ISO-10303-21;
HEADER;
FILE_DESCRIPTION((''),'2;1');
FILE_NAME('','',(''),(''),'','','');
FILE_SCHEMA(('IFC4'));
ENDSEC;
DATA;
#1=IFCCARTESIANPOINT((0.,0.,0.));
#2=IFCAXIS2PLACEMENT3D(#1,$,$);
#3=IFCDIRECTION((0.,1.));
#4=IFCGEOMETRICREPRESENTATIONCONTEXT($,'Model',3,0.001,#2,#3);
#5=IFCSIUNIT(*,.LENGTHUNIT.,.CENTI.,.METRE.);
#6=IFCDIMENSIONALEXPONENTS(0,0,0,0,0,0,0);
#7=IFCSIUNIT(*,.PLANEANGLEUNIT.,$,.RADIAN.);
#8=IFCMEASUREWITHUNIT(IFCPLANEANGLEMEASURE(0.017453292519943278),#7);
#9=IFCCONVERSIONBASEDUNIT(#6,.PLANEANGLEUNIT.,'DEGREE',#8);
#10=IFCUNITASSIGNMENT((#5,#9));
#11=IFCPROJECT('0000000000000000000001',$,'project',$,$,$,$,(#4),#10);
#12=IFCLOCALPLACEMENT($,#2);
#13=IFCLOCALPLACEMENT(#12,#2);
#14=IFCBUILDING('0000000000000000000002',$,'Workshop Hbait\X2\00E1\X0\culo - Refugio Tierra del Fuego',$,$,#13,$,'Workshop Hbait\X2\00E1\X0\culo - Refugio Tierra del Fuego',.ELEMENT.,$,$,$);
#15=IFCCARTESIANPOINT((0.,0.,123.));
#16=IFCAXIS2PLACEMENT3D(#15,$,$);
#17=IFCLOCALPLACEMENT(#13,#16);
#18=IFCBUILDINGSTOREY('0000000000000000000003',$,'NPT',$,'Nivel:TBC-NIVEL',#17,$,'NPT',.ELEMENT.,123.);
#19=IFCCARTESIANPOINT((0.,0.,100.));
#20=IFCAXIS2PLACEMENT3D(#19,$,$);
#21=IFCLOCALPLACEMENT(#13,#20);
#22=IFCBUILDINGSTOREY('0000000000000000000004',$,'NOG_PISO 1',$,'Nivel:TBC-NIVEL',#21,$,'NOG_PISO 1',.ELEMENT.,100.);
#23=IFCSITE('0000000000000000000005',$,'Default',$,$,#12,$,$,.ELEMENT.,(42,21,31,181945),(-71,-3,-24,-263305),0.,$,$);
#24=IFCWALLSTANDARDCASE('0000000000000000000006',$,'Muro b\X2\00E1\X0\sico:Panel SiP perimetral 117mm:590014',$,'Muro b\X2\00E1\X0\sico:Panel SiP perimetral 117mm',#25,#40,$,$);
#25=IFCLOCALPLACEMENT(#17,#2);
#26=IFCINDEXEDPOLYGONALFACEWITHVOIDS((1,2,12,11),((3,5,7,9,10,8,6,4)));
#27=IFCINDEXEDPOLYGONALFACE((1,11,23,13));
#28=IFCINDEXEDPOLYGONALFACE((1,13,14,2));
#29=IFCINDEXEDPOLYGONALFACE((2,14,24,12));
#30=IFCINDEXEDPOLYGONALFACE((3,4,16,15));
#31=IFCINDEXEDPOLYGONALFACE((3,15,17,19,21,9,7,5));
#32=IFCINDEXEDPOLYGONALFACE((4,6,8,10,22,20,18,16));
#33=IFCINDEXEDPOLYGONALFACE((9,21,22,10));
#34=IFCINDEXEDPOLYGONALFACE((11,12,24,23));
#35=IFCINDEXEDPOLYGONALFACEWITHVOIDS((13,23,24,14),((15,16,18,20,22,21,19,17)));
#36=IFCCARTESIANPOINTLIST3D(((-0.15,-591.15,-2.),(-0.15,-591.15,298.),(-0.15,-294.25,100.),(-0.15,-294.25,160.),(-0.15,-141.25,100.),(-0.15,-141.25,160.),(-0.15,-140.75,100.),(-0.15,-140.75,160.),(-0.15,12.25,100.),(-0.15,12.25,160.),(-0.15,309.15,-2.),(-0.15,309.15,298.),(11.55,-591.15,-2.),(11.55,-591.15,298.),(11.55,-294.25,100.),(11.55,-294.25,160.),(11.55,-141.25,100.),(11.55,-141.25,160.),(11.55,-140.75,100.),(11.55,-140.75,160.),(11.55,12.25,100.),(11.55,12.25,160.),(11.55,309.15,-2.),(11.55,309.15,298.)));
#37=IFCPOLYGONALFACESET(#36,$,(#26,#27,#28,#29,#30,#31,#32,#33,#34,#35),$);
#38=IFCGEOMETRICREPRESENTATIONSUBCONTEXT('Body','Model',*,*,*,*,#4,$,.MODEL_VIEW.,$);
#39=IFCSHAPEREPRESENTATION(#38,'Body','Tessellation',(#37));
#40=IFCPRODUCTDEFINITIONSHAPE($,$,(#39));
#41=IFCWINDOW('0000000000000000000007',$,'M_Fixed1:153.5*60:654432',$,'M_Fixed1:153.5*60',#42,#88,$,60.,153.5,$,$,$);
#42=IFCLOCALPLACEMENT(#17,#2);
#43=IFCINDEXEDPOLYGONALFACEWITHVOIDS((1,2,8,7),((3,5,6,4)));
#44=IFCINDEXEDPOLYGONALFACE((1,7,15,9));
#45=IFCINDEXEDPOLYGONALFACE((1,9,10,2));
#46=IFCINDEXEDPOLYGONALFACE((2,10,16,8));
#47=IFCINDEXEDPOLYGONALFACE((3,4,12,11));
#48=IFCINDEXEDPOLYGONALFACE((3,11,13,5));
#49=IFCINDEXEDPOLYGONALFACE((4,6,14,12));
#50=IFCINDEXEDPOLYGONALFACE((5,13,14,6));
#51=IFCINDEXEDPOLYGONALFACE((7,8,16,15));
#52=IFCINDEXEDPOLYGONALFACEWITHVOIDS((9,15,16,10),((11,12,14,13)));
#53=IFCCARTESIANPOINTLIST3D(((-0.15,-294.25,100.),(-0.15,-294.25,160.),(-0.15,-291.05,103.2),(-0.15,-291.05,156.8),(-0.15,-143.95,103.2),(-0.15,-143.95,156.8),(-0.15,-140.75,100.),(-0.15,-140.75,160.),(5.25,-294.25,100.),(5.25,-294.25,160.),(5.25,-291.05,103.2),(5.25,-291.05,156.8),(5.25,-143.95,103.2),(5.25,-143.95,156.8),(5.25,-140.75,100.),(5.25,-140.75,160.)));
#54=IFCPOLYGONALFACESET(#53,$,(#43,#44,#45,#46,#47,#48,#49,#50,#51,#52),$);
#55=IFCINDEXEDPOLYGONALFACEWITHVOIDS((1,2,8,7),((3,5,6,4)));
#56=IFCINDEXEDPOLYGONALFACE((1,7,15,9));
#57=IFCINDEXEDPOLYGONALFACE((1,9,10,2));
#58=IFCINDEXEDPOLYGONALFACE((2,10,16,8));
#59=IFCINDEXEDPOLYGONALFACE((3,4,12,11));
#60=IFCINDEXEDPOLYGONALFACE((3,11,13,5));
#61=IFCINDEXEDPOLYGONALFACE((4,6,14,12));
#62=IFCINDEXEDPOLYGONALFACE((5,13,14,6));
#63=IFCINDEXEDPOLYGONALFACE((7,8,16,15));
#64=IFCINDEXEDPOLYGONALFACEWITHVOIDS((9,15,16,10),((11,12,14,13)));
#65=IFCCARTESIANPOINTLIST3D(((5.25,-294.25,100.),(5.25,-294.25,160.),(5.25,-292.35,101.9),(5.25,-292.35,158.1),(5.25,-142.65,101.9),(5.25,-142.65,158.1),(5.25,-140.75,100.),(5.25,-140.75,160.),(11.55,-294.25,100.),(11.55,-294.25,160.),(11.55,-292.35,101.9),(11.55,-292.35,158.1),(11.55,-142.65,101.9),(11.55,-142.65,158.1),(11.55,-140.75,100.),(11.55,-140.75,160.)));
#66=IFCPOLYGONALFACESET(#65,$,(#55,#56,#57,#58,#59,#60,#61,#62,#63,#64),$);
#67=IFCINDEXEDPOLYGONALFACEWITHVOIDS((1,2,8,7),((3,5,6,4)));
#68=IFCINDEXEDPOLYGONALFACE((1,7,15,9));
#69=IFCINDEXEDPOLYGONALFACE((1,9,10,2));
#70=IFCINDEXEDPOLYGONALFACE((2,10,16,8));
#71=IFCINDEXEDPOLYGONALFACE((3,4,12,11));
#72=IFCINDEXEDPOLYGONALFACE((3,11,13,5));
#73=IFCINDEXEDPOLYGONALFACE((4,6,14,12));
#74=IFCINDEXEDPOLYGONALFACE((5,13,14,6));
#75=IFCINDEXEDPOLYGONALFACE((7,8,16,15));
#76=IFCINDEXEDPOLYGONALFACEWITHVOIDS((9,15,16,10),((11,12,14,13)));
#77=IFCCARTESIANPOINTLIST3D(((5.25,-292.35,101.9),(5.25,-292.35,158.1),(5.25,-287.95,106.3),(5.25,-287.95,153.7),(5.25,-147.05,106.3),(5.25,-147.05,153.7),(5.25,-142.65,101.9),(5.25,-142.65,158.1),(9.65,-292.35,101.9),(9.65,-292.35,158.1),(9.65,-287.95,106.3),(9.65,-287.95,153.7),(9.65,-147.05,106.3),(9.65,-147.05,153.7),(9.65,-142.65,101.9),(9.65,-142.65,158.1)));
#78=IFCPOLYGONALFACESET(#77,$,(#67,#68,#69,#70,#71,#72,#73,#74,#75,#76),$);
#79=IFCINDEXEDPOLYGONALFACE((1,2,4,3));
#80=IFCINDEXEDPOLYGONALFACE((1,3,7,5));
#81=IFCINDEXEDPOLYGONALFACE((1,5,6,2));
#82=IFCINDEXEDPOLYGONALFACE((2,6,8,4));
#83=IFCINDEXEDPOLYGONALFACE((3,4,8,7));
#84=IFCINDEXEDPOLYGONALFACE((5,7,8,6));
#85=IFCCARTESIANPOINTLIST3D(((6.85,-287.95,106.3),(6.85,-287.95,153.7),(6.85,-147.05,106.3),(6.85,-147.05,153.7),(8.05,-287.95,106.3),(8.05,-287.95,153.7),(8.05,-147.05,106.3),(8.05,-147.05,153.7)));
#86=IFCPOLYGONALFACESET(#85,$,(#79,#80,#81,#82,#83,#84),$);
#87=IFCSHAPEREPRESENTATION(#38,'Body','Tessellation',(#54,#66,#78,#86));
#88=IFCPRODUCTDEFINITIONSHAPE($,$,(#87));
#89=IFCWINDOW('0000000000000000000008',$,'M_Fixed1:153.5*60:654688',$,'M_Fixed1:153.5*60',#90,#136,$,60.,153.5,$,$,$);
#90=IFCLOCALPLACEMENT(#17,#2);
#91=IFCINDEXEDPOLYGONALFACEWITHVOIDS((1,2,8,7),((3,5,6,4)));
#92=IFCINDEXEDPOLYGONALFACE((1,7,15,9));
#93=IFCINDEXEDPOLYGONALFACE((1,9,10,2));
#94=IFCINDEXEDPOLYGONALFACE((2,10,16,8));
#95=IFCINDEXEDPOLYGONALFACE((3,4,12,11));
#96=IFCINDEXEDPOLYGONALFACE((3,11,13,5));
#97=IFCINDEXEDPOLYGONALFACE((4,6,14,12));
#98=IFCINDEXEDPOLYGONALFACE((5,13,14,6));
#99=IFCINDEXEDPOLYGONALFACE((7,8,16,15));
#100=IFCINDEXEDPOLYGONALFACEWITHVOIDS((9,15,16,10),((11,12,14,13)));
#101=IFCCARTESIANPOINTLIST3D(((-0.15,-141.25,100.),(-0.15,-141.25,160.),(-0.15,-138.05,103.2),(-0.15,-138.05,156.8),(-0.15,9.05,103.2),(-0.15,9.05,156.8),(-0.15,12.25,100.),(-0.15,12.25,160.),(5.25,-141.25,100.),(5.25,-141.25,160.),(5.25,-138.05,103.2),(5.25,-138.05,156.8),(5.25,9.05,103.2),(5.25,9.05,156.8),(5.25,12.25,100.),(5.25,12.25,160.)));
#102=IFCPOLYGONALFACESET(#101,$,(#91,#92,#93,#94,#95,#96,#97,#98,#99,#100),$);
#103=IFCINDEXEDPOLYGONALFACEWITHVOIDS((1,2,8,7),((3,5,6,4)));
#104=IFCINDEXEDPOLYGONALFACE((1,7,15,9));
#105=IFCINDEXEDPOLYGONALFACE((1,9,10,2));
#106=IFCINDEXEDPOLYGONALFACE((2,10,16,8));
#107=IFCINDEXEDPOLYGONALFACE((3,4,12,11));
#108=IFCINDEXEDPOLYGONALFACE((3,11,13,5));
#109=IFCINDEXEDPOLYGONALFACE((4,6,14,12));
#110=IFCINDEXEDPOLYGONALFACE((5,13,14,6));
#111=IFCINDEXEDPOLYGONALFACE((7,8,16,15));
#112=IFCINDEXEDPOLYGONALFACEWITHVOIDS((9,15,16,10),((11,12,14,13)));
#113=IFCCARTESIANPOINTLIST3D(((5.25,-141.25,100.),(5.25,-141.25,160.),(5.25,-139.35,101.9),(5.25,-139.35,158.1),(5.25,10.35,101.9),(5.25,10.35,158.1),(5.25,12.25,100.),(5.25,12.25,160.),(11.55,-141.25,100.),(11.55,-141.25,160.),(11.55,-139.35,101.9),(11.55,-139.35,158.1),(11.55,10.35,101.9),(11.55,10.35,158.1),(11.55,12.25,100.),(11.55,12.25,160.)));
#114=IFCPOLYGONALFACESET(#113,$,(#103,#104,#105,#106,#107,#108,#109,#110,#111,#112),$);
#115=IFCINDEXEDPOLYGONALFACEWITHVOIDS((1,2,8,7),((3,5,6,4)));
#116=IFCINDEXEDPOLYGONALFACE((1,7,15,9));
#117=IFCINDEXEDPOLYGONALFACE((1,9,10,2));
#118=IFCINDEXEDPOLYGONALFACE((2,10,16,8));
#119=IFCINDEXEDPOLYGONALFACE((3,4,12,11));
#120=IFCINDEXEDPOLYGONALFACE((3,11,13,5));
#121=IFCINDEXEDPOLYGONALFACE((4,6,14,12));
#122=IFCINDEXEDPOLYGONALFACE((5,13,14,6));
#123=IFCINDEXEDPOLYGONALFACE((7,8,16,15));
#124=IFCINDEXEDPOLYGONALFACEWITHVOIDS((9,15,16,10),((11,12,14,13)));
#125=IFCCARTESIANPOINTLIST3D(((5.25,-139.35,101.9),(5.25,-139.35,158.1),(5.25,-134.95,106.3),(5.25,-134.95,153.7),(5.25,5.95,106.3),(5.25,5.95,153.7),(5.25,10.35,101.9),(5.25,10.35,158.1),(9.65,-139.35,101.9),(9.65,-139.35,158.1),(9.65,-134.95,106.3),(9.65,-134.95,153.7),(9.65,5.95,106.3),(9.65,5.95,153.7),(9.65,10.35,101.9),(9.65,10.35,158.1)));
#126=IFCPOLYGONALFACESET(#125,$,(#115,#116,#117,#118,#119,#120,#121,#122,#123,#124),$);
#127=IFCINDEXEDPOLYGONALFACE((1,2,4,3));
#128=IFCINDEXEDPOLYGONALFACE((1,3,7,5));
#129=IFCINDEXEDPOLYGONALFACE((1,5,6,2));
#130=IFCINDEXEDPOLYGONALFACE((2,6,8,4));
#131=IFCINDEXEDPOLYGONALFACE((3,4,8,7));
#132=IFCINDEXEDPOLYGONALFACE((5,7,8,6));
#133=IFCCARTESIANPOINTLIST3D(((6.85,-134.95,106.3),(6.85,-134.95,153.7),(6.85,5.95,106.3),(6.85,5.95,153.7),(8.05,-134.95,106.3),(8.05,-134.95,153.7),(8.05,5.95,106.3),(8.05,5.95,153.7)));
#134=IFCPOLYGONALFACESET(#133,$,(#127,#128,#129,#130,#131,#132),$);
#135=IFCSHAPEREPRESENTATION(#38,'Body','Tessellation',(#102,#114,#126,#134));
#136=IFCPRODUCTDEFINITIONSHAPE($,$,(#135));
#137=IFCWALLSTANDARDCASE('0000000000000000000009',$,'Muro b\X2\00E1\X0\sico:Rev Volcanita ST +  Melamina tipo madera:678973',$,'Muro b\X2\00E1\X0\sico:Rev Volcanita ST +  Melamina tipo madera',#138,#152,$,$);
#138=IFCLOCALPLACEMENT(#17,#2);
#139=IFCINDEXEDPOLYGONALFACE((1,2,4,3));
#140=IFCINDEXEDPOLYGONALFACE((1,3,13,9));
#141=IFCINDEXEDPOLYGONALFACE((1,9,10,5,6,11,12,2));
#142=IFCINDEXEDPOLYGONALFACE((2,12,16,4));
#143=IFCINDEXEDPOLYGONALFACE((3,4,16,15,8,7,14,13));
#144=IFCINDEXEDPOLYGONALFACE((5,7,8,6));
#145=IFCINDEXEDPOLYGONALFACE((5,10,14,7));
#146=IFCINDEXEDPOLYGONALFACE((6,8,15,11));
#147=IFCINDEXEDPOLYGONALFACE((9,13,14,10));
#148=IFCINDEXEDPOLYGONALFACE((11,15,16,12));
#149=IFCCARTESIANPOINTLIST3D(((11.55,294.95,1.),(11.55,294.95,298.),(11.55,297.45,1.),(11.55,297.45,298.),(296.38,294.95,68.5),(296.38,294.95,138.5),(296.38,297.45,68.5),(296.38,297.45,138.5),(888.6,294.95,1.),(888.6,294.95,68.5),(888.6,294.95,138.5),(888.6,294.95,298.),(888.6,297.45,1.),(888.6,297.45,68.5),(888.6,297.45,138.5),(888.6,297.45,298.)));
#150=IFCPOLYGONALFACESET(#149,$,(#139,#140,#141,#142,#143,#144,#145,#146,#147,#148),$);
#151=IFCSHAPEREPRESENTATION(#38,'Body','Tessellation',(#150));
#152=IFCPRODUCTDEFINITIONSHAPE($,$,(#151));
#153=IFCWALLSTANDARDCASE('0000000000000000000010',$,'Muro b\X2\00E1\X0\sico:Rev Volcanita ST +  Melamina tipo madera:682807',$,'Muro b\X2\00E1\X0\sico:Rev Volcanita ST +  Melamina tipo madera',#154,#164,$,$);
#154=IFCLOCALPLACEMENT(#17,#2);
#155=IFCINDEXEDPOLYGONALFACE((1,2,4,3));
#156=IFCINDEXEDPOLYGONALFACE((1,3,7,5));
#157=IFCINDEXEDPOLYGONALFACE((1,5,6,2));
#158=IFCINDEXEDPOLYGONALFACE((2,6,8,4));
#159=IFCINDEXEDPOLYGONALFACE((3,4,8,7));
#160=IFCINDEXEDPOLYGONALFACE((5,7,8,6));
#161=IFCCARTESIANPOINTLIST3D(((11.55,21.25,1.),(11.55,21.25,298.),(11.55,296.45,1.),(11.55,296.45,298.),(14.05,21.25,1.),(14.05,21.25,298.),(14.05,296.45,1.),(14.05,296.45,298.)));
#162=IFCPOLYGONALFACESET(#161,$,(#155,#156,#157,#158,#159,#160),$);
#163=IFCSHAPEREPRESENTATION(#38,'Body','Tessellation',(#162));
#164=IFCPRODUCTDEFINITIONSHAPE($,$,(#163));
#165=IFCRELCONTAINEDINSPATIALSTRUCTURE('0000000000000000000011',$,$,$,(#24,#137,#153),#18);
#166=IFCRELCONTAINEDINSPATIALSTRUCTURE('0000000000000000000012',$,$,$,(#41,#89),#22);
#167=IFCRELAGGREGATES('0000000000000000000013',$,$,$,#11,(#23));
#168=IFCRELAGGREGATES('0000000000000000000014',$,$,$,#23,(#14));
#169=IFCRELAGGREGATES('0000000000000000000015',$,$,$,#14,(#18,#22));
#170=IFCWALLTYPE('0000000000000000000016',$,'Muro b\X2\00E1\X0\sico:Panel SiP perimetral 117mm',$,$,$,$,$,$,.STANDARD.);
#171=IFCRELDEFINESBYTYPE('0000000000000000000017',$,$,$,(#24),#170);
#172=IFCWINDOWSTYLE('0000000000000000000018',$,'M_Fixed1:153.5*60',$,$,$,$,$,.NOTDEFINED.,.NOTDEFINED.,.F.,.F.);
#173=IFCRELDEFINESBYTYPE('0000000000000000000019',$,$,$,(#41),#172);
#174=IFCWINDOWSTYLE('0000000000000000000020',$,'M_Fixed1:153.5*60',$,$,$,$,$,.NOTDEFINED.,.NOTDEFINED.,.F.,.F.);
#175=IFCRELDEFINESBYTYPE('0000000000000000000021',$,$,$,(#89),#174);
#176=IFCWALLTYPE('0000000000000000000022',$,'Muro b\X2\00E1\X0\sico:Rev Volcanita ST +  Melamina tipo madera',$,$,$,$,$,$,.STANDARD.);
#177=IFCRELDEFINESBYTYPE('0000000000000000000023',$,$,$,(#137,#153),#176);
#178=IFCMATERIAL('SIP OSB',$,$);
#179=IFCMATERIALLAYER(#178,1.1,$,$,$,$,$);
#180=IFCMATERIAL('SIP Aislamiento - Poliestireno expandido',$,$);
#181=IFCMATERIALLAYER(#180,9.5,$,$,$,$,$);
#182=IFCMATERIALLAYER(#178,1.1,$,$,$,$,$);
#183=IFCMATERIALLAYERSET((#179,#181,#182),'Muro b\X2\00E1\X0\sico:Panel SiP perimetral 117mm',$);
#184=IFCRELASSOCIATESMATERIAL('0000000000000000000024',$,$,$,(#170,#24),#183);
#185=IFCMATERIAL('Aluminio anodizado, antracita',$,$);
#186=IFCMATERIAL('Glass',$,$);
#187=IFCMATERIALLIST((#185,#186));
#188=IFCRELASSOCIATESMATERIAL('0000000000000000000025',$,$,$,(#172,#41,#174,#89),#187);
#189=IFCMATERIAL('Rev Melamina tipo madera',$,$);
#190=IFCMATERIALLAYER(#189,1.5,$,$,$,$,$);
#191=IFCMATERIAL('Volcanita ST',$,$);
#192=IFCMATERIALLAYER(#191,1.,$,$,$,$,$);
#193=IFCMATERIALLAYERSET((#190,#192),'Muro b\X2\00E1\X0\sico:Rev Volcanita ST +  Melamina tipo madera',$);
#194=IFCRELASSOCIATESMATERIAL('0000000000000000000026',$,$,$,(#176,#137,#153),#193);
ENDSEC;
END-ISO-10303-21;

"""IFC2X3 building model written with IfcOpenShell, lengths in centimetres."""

from ifc_helpers import new_model, entity, si_unit, converted_unit, direction, frame, frame_2d, origin, origin_2d_with_axis, place, context, subcontext, project, spatial, polyline, rectangle, outline, extrude, source, transform, mapped, material, material_list, layer, layer_set, layer_usage, type_object, type_shapes, element, fill, save


model = new_model("IFC2X3")

# Units and contexts
model_context = context("Model", 3, precision=0.001, world=origin(), true_north=direction((0.0, 1.0)))
body_context = subcontext(model_context, "Body", "Model", "MODEL_VIEW")
ifc_project = project(units=[si_unit("LENGTHUNIT", "METRE", prefix="CENTI"), converted_unit("PLANEANGLEUNIT", "DEGREE", entity("IfcPlaneAngleMeasure", 0.017453292519943278), si_unit("PLANEANGLEUNIT", "RADIAN"), dimensions=[0, 0, 0, 0, 0, 0, 0])], contexts=[model_context])

# Site, building, storey
site_placement = place(None, origin())
site = spatial("IfcSite", under=ifc_project, at=site_placement, Name="Default", CompositionType="ELEMENT", RefLatitude=(42, 21, 31, 181945), RefLongitude=(-71, -3, -24, -263305), RefElevation=0.0)
building_placement = place(site_placement, origin())
building = spatial("IfcBuilding", under=site, at=building_placement, Name="Workshop Hbaitáculo - Refugio Tierra del Fuego", LongName="Workshop Hbaitáculo - Refugio Tierra del Fuego", CompositionType="ELEMENT")
storey_1_placement = place(building_placement, frame((0.0, 0.0, 123.0)))
storey_1 = spatial("IfcBuildingStorey", under=building, at=storey_1_placement, Name="NPT", ObjectType="Nivel:TBC-NIVEL", LongName="NPT", CompositionType="ELEMENT", Elevation=123.0)

# Wall, openings
ifc_material_1 = material(Name="SIP OSB")
ifc_layer_1 = layer(ifc_material_1, 1.1)
ifc_material_2 = material(Name="SIP Aislamiento - Poliestireno expandido")
ifc_layer_2 = layer(ifc_material_2, 9.5)
ifc_layer_3 = layer(ifc_material_1, 1.1)
ifc_layer_set_1 = layer_set([ifc_layer_1, ifc_layer_2, ifc_layer_3], Name="Muro básico:Panel SiP perimetral 117mm")
ifc_layer_usage_1 = layer_usage(ifc_layer_set_1, "AXIS2", "NEGATIVE", 5.85)
wall_type_1 = type_object("IfcWallType", Name="Muro básico:Panel SiP perimetral 117mm", PredefinedType="STANDARD", material=ifc_layer_set_1)
wall_1_placement = place(storey_1_placement, frame((5.7, 309.15, -2.0), z_axis=(0.0, 0.0, 1.0), x_axis=(0.0, -1.0, 0.0)))
wall_1 = element("IfcWallStandardCase", 1, at=wall_1_placement, inside=storey_1, type_object=wall_type_1, material=ifc_layer_usage_1, Name="Muro básico:Panel SiP perimetral 117mm:590014", ObjectType="Muro básico:Panel SiP perimetral 117mm", context=body_context, shape_type="SweptSolid", body=[
    extrude(rectangle(XDim=900.3, YDim=11.7, at=frame_2d((450.15, 0.0), x_axis=(-1.0, 0.0))), origin(), (0.0, 0.0, 1.0), 300.0),
])
opening_1_placement = place(wall_1_placement, frame((449.9, -5.85, 102.0)))
opening_1 = element("IfcOpeningElement", 2, at=opening_1_placement, cuts=wall_1, ObjectType="Opening", context=body_context, shape_type="SweptSolid", body=[
    extrude(rectangle(XDim=60.0, YDim=153.5, at=frame_2d((30.0, 76.75), x_axis=(1.0, 0.0))), frame((0.0, 0.0, 0.0), z_axis=(0.0, 1.0, 0.0), x_axis=(0.0, 0.0, 1.0)), (0.0, 0.0, 1.0), 11.7),
])
opening_2_placement = place(wall_1_placement, frame((296.9, -5.85, 102.0)))
opening_2 = element("IfcOpeningElement", 3, at=opening_2_placement, cuts=wall_1, ObjectType="Opening", context=body_context, shape_type="SweptSolid", body=[
    extrude(rectangle(XDim=60.0, YDim=153.5, at=frame_2d((30.0, 76.75), x_axis=(1.0, 0.0))), frame((0.0, 0.0, 0.0), z_axis=(0.0, 1.0, 0.0), x_axis=(0.0, 0.0, 1.0)), (0.0, 0.0, 1.0), 11.7),
])

# Shared definitions
storey_2_placement = place(building_placement, frame((0.0, 0.0, 100.0)))
storey_2 = spatial("IfcBuildingStorey", under=building, at=storey_2_placement, Name="NOG_PISO 1", ObjectType="Nivel:TBC-NIVEL", LongName="NOG_PISO 1", CompositionType="ELEMENT", Elevation=100.0)

# Windows
ifc_material_3 = material(Name="Aluminio anodizado, antracita")
ifc_material_4 = material(Name="Glass")
ifc_material_list_1 = material_list([ifc_material_3, ifc_material_4])
window_style_1 = type_object("IfcWindowStyle", Name="M_Fixed1:153.5*60", ConstructionType="NOTDEFINED", OperationType="NOTDEFINED", ParameterTakesPrecedence=False, Sizeable=False, material=ifc_material_list_1)
shared_shape_1 = source(origin(), body_context, "Body", "SweptSolid", [
    extrude(outline(polyline([(-76.75, -30.0), (76.75, -30.0), (76.75, 30.0), (-76.75, 30.0), (-76.75, -30.0)]), holes=[polyline([(-73.55, -26.8), (-73.55, 26.8), (73.55, 26.8), (73.55, -26.8), (-73.55, -26.8)])]), frame((76.75, 0.0, 30.0), z_axis=(0.0, 1.0, 0.0), x_axis=(1.0, 0.0, 0.0)), (0.0, 0.0, 1.0), 5.4),
    extrude(outline(polyline([(-76.75, -30.0), (76.75, -30.0), (76.75, 30.0), (-76.75, 30.0), (-76.75, -30.0)]), holes=[polyline([(-74.85, -28.1), (-74.85, 28.1), (74.85, 28.1), (74.85, -28.1), (-74.85, -28.1)])]), frame((76.75, 5.4, 30.0), z_axis=(0.0, 1.0, 0.0), x_axis=(1.0, 0.0, 0.0)), (0.0, 0.0, 1.0), 6.3),
    extrude(outline(polyline([(-74.85, -28.1), (74.85, -28.1), (74.85, 28.1), (-74.85, 28.1), (-74.85, -28.1)]), holes=[polyline([(-70.45, -23.7), (-70.45, 23.7), (70.45, 23.7), (70.45, -23.7), (-70.45, -23.7)])]), frame((76.75, 5.4, 30.0), z_axis=(0.0, 1.0, 0.0), x_axis=(1.0, 0.0, 0.0)), (0.0, 0.0, 1.0), 4.4),
    extrude(rectangle(XDim=1.2, YDim=140.9, at=origin_2d_with_axis()), frame((76.75, 7.6, 6.3), z_axis=(0.0, 0.0, 1.0), x_axis=(0.0, -1.0, 0.0)), (0.0, 0.0, 1.0), 47.4),
])
type_shapes(window_style_1, [shared_shape_1])
window_1_placement = place(opening_1_placement, origin())
window_1 = element("IfcWindow", 4, at=window_1_placement, inside=storey_2, type_object=window_style_1, material=ifc_material_list_1, Name="M_Fixed1:153.5*60:654432", ObjectType="M_Fixed1:153.5*60", OverallHeight=60.0, OverallWidth=153.5, context=body_context, shape_type="MappedRepresentation", body=[
    mapped(shared_shape_1, transform((0.0, 0.0, 0.0), scale=1.0)),
])
fill(opening_1, window_1)
window_style_2 = type_object("IfcWindowStyle", Name="M_Fixed1:153.5*60", ConstructionType="NOTDEFINED", OperationType="NOTDEFINED", ParameterTakesPrecedence=False, Sizeable=False, material=ifc_material_list_1)
shared_shape_2 = source(origin(), body_context, "Body", "SweptSolid", [
    extrude(outline(polyline([(-76.75, -30.0), (76.75, -30.0), (76.75, 30.0), (-76.75, 30.0), (-76.75, -30.0)]), holes=[polyline([(-73.55, -26.8), (-73.55, 26.8), (73.55, 26.8), (73.55, -26.8), (-73.55, -26.8)])]), frame((76.75, 8.0, 30.0), z_axis=(0.0, -1.0, 0.0), x_axis=(-1.0, 0.0, 0.0)), (0.0, 0.0, 1.0), 5.4),
    extrude(outline(polyline([(-76.75, -30.0), (76.75, -30.0), (76.75, 30.0), (-76.75, 30.0), (-76.75, -30.0)]), holes=[polyline([(-74.85, -28.1), (-74.85, 28.1), (74.85, 28.1), (74.85, -28.1), (-74.85, -28.1)])]), frame((76.75, 14.3, 30.0), z_axis=(0.0, -1.0, 0.0), x_axis=(-1.0, 0.0, 0.0)), (0.0, 0.0, 1.0), 6.3),
    extrude(outline(polyline([(-74.85, -28.1), (74.85, -28.1), (74.85, 28.1), (-74.85, 28.1), (-74.85, -28.1)]), holes=[polyline([(-70.45, -23.7), (-70.45, 23.7), (70.45, 23.7), (70.45, -23.7), (-70.45, -23.7)])]), frame((76.75, 12.4, 30.0), z_axis=(0.0, -1.0, 0.0), x_axis=(-1.0, 0.0, 0.0)), (0.0, 0.0, 1.0), 4.4),
    extrude(rectangle(XDim=140.9, YDim=1.2, at=origin_2d_with_axis()), frame((76.75, 10.2, 6.3), z_axis=(0.0, 0.0, 1.0), x_axis=(-1.0, 0.0, 0.0)), (0.0, 0.0, 1.0), 47.4),
])
type_shapes(window_style_2, [shared_shape_2])
window_2_placement = place(opening_2_placement, frame((0.0, -2.6, 0.0)))
window_2 = element("IfcWindow", 5, at=window_2_placement, inside=storey_2, type_object=window_style_2, material=ifc_material_list_1, Name="M_Fixed1:153.5*60:654688", ObjectType="M_Fixed1:153.5*60", OverallHeight=60.0, OverallWidth=153.5, context=body_context, shape_type="MappedRepresentation", body=[
    mapped(shared_shape_2, transform((0.0, 0.0, 0.0), scale=1.0)),
])
fill(opening_2, window_2)

# Wall, opening
ifc_material_5 = material(Name="Rev Melamina tipo madera")
ifc_layer_4 = layer(ifc_material_5, 1.5)
ifc_material_6 = material(Name="Volcanita ST")
ifc_layer_5 = layer(ifc_material_6, 1.0)
ifc_layer_set_2 = layer_set([ifc_layer_4, ifc_layer_5], Name="Muro básico:Rev Volcanita ST +  Melamina tipo madera")
ifc_layer_usage_2 = layer_usage(ifc_layer_set_2, "AXIS2", "POSITIVE", -1.25)
wall_type_2 = type_object("IfcWallType", Name="Muro básico:Rev Volcanita ST +  Melamina tipo madera", PredefinedType="STANDARD", material=ifc_layer_set_2)
wall_2_placement = place(storey_1_placement, frame((11.55, 296.2, 1.0)))
wall_2 = element("IfcWallStandardCase", 6, at=wall_2_placement, inside=storey_1, type_object=wall_type_2, material=ifc_layer_usage_2, Name="Muro básico:Rev Volcanita ST +  Melamina tipo madera:678973", ObjectType="Muro básico:Rev Volcanita ST +  Melamina tipo madera", context=body_context, shape_type="SweptSolid", body=[
    extrude(rectangle(XDim=877.05, YDim=2.5, at=frame_2d((438.53, 0.0), x_axis=(-1.0, 0.0))), origin(), (0.0, 0.0, 1.0), 297.0),
])
opening_3_placement = place(wall_2_placement, origin())
element("IfcOpeningElement", 7, at=opening_3_placement, cuts=wall_2, ObjectType="Opening", context=body_context, shape_type="SweptSolid", body=[
    extrude(rectangle(XDim=70.0, YDim=592.22, at=frame_2d((0.0, 0.0), x_axis=(1.0, 0.0))), frame((580.94, 1.25, 102.5), z_axis=(0.0, -1.0, 0.0), x_axis=(0.0, 0.0, 1.0)), (0.0, 0.0, 1.0), 2.5),
])

# Wall
ifc_layer_usage_3 = layer_usage(ifc_layer_set_2, "AXIS2", "NEGATIVE", 1.25)
wall_3_placement = place(storey_1_placement, frame((12.8, 296.45, 1.0), z_axis=(0.0, 0.0, 1.0), x_axis=(0.0, -1.0, 0.0)))
element("IfcWallStandardCase", 8, at=wall_3_placement, inside=storey_1, type_object=wall_type_2, material=ifc_layer_usage_3, Name="Muro básico:Rev Volcanita ST +  Melamina tipo madera:682807", ObjectType="Muro básico:Rev Volcanita ST +  Melamina tipo madera", context=body_context, shape_type="SweptSolid", body=[
    extrude(rectangle(XDim=275.2, YDim=2.5, at=frame_2d((137.6, 0.0), x_axis=(-1.0, 0.0))), origin(), (0.0, 0.0, 1.0), 297.0),
])

save(model, "model.ifc")
